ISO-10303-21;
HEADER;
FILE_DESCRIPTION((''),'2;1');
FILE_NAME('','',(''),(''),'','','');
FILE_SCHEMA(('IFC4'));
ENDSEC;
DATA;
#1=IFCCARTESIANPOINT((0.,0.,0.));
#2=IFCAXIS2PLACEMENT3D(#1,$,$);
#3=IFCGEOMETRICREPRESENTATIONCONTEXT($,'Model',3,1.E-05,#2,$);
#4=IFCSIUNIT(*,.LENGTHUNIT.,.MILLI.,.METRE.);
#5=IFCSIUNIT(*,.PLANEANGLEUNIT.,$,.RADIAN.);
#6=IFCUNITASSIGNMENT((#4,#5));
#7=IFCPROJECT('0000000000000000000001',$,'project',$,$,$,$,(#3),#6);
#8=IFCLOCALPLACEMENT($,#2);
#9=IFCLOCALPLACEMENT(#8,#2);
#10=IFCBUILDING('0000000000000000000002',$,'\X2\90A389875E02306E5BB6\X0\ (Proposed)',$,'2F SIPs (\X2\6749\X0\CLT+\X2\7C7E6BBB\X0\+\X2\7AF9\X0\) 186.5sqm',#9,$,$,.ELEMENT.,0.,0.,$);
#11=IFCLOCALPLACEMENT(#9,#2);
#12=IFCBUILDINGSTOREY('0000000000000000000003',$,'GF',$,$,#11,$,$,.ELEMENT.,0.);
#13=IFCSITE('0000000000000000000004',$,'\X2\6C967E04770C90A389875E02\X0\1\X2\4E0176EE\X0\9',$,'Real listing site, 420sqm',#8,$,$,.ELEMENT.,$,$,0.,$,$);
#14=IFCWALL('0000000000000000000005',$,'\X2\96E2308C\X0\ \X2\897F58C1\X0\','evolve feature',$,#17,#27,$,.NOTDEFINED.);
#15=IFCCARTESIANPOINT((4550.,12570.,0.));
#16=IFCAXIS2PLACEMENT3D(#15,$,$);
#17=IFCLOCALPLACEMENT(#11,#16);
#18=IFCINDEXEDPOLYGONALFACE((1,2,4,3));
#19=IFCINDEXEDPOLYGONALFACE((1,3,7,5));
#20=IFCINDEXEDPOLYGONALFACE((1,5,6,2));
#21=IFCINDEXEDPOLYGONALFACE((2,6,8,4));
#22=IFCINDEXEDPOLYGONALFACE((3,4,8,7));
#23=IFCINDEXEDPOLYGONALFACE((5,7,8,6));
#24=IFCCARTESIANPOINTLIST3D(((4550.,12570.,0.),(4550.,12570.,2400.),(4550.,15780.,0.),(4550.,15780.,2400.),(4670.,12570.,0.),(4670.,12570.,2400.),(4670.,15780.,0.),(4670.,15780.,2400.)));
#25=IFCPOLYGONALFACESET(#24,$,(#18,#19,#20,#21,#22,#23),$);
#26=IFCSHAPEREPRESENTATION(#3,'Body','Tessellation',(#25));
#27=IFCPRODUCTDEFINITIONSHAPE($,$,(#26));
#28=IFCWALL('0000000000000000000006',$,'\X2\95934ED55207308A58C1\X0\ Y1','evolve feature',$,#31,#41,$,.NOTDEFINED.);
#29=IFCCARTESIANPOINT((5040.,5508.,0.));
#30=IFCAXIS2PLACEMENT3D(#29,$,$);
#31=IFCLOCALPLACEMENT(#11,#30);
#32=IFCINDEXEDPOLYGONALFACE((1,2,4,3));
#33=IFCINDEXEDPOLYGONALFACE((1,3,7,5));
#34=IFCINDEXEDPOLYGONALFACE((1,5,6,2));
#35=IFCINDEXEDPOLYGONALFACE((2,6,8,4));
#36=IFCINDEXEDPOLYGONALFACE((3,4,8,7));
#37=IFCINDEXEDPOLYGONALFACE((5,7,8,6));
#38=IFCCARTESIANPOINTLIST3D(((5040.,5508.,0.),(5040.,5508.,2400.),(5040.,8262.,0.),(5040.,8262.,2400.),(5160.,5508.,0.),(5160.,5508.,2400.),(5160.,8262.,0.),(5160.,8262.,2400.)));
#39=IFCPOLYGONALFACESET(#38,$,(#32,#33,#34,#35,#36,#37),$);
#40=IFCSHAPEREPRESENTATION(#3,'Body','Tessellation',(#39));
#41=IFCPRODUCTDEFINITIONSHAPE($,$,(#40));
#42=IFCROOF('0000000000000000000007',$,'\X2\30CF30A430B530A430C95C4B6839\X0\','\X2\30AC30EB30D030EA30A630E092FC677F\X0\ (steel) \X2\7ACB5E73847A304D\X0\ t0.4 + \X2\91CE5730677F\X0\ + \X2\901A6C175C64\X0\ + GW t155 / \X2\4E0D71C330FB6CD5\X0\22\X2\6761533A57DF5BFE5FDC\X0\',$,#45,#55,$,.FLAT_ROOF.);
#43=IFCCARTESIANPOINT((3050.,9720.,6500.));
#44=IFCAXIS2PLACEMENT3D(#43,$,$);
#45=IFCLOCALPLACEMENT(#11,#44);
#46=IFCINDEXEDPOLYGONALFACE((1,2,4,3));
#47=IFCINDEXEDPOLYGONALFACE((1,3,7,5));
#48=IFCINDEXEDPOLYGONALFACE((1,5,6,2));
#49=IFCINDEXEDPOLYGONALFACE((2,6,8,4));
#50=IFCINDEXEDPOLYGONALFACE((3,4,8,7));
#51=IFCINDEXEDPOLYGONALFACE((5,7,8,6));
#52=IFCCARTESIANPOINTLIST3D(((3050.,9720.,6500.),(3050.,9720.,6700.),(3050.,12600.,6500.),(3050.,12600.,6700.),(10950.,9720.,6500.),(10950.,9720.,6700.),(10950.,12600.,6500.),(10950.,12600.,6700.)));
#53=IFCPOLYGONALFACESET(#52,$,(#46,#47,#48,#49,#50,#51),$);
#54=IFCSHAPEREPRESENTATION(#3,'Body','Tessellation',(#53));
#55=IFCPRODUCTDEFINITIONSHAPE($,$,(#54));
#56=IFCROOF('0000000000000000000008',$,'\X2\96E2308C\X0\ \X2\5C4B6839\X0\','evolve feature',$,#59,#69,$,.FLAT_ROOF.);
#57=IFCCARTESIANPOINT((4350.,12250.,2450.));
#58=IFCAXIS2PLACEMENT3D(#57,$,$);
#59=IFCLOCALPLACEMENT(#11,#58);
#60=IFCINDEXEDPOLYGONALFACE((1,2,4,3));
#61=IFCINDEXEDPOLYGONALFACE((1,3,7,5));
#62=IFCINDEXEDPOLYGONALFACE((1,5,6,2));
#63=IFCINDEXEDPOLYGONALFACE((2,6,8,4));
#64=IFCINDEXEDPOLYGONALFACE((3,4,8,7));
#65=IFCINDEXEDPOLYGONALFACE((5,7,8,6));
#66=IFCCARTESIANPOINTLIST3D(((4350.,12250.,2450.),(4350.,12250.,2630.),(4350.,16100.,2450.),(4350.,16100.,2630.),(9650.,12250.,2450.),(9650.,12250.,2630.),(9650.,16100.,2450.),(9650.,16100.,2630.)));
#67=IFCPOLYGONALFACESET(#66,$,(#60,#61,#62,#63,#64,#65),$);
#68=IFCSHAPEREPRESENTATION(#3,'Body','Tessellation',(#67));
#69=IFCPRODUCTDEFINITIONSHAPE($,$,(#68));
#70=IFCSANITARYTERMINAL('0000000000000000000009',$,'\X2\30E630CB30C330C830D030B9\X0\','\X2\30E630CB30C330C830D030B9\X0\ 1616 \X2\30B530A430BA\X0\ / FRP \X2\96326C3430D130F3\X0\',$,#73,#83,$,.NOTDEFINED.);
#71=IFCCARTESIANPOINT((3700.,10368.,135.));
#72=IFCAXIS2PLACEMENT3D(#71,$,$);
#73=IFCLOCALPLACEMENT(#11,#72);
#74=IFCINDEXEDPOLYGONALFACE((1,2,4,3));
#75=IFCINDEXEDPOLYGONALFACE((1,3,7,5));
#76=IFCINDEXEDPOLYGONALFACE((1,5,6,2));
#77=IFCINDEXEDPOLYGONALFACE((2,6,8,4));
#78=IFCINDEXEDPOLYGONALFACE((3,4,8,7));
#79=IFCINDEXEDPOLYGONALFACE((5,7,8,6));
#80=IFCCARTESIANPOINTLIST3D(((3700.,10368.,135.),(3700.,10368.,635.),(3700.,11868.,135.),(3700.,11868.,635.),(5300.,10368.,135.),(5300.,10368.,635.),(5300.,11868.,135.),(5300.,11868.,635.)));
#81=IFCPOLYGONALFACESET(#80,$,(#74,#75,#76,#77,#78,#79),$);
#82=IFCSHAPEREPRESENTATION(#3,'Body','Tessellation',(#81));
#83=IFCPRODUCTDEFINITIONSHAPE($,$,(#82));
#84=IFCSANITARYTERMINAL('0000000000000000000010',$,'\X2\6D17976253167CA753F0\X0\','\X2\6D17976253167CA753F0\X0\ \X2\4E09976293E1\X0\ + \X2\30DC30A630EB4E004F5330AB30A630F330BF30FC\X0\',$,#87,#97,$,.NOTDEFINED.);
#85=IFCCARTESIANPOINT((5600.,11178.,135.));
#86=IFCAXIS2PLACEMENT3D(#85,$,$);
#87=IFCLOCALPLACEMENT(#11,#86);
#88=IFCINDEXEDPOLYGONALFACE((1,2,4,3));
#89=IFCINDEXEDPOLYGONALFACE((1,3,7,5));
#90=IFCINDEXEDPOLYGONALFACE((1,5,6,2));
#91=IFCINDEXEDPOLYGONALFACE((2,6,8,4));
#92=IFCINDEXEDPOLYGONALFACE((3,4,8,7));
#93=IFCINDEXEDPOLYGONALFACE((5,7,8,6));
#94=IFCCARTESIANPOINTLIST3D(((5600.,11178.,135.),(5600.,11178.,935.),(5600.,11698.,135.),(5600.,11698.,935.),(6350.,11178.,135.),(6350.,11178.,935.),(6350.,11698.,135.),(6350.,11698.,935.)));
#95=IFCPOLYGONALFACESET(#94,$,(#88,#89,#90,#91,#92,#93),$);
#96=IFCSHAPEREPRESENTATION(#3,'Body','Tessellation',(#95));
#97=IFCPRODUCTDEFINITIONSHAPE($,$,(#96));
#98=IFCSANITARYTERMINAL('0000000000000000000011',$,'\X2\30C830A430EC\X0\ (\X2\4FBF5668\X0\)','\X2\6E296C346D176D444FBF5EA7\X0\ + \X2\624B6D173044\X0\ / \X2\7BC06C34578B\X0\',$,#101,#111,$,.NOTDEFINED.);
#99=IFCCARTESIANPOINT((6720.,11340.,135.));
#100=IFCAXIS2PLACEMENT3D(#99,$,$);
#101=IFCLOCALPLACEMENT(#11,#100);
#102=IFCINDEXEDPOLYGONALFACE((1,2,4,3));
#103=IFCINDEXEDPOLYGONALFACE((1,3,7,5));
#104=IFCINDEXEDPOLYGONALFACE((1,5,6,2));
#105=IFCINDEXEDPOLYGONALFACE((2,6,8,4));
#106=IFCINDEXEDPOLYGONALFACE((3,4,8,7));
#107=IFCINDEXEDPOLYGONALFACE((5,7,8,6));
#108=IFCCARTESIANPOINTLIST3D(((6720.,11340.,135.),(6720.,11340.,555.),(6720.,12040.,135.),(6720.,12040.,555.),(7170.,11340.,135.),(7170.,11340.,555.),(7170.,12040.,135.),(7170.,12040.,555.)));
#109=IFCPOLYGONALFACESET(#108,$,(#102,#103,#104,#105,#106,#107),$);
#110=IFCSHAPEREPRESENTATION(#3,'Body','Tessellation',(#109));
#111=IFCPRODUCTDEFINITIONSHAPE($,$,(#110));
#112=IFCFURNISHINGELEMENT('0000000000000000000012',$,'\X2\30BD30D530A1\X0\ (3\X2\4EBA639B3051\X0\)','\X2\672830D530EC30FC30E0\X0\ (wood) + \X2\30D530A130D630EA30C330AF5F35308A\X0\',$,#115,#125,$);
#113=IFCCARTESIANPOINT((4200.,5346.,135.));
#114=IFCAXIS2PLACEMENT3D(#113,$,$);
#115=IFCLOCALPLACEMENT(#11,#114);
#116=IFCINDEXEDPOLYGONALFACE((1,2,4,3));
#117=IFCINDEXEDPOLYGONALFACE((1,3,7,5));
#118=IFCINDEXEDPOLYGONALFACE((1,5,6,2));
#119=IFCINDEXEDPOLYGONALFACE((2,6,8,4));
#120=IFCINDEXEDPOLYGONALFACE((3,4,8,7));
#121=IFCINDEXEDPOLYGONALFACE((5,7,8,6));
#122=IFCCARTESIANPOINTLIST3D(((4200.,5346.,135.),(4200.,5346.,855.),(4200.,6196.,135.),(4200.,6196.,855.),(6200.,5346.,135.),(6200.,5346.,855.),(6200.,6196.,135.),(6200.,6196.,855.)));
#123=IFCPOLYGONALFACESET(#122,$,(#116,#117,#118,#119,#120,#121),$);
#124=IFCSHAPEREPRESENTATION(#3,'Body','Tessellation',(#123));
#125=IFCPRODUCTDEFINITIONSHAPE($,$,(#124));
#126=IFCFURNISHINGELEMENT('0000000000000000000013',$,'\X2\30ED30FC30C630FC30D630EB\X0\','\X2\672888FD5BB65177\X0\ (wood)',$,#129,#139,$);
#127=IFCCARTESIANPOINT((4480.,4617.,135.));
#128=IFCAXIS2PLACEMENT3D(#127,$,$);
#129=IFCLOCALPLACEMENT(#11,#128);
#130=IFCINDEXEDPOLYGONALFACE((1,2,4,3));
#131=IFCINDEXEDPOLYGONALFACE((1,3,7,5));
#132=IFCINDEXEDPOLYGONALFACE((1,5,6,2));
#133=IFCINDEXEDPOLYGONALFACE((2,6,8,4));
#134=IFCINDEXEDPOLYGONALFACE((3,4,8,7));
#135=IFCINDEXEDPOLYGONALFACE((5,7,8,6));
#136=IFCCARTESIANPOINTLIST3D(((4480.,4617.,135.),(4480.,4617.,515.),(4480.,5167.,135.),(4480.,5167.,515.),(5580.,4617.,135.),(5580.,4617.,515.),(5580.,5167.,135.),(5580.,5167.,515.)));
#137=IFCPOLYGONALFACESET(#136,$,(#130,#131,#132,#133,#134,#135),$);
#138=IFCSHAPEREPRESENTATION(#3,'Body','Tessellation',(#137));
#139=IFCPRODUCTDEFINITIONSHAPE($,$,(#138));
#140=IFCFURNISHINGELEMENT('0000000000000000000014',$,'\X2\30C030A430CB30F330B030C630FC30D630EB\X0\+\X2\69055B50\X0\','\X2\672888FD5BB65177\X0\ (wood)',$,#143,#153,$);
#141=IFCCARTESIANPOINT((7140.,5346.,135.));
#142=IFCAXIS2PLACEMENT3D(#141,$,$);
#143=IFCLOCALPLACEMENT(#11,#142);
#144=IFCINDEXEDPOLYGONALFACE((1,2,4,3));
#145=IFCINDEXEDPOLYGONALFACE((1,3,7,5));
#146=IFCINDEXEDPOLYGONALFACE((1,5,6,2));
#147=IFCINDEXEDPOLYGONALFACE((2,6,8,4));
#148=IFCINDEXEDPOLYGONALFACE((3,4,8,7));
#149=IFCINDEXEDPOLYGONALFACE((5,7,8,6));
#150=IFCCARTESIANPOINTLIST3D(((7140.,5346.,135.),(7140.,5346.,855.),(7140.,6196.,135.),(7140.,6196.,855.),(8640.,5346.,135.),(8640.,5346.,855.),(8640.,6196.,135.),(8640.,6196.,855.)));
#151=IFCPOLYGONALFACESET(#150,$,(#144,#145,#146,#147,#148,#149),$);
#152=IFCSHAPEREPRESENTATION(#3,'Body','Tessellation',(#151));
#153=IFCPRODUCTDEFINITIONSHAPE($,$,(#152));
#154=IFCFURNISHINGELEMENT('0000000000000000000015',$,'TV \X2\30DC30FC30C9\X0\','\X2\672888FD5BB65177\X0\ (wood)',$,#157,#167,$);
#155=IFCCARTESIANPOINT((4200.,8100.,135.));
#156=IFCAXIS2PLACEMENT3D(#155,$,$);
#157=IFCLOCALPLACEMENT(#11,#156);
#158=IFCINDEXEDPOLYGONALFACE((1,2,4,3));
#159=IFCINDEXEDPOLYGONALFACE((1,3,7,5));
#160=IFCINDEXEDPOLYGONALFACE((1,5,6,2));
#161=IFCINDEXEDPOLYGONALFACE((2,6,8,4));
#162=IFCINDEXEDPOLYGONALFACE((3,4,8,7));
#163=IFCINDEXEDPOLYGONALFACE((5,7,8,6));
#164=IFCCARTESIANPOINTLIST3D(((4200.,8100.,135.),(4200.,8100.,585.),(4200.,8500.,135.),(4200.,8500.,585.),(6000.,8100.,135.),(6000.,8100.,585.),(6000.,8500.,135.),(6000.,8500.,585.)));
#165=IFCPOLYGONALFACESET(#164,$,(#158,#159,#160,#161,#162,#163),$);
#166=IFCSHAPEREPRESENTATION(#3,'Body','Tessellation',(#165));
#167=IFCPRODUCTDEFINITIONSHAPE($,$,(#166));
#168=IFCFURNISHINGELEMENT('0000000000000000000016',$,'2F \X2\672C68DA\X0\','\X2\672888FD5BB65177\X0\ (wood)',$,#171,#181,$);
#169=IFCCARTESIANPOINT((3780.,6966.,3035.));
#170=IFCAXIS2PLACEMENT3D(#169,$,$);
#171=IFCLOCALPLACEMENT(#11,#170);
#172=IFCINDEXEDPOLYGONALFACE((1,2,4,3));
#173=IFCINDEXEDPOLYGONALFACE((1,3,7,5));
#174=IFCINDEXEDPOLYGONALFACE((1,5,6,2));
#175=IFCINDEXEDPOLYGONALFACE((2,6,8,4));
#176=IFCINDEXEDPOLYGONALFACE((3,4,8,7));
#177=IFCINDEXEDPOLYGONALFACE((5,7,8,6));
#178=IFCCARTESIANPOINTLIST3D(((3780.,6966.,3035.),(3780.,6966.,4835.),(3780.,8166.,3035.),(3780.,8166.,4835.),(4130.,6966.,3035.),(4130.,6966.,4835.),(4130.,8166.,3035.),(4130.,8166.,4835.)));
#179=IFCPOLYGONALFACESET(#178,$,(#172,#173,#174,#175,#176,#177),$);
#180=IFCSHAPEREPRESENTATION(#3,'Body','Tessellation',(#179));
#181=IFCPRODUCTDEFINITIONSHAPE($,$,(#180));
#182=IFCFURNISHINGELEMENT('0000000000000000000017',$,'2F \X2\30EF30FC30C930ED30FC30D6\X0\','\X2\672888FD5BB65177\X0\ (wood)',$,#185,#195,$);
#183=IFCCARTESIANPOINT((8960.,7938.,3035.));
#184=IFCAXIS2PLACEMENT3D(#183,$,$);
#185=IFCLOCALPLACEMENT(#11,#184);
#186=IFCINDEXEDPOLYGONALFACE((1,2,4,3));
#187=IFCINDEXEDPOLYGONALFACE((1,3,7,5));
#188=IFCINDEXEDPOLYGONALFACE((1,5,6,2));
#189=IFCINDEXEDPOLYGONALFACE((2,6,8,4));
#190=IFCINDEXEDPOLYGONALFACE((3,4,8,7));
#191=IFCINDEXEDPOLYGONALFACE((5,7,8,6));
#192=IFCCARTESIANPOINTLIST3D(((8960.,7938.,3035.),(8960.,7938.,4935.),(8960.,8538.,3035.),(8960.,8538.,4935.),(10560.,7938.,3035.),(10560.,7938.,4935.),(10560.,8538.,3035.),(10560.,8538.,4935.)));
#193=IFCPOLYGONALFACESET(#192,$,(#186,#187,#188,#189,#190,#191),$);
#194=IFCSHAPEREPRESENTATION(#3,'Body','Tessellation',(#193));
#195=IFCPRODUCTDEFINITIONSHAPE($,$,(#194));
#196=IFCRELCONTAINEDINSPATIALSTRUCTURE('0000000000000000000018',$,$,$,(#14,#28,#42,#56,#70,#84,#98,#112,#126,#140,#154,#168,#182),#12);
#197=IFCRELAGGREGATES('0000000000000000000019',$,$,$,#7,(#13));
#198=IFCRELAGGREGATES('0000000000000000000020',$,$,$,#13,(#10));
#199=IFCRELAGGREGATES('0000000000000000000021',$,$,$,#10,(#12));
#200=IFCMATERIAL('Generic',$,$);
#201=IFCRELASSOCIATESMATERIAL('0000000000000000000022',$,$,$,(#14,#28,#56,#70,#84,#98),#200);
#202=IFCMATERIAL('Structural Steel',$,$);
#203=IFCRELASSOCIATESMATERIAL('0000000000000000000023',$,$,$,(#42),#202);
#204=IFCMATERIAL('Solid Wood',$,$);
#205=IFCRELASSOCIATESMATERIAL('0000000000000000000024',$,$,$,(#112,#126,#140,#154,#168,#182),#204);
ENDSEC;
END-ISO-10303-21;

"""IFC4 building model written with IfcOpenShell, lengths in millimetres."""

from ifc_helpers import new_model, si_unit, frame, frame_2d, origin, place, context, project, spatial, rectangle, extrude, material, element, save


model = new_model("IFC4")

# Units and contexts
model_context = context("Model", 3, precision=1e-05, world=origin())
ifc_project = project(units=[si_unit("LENGTHUNIT", "METRE", prefix="MILLI"), si_unit("PLANEANGLEUNIT", "RADIAN")], contexts=[model_context])

# Site, building, storey
site_placement = place(None, origin())
site = spatial("IfcSite", under=ifc_project, at=site_placement, Name="沖縄県那覇市1丁目9", ObjectType="Real listing site, 420sqm", CompositionType="ELEMENT", RefElevation=0.0)
building_placement = place(site_placement, origin())
building = spatial("IfcBuilding", under=site, at=building_placement, Name="那覇市の家 (Proposed)", ObjectType="2F SIPs (杉CLT+籾殻+竹) 186.5sqm", CompositionType="ELEMENT", ElevationOfRefHeight=0.0, ElevationOfTerrain=0.0)
storey_placement = place(building_placement, origin())
storey = spatial("IfcBuildingStorey", under=building, at=storey_placement, Name="GF", CompositionType="ELEMENT", Elevation=0.0)

# Shared definitions
ifc_material_1 = material(Name="Generic")

# Shared definitions
ifc_material_2 = material(Name="Solid Wood")

# Walls
wall_1_placement = place(storey_placement, frame((4550.0, 12570.0, 0.0)))
element("IfcWall", 1, at=wall_1_placement, inside=storey, material=ifc_material_1, Name="離れ 西壁", Description="evolve feature", PredefinedType="NOTDEFINED", context=model_context, shape_type="SweptSolid", body=[
    extrude(rectangle(XDim=120.0, YDim=3210.0, at=frame_2d((60.0, 1605.0))), frame((4550.0, 12570.0, 0.0)), (0.0, 0.0, 1.0), 2400.0),
])
wall_2_placement = place(storey_placement, frame((5040.0, 5508.0, 0.0)))
element("IfcWall", 2, at=wall_2_placement, inside=storey, material=ifc_material_1, Name="間仕切り壁 Y1", Description="evolve feature", PredefinedType="NOTDEFINED", context=model_context, shape_type="SweptSolid", body=[
    extrude(rectangle(XDim=120.0, YDim=2754.0, at=frame_2d((60.0, 1377.0))), frame((5040.0, 5508.0, 0.0)), (0.0, 0.0, 1.0), 2400.0),
])

# Roofs
ifc_material_3 = material(Name="Structural Steel")
roof_1_placement = place(storey_placement, frame((3050.0, 9720.0, 6500.0)))
element("IfcRoof", 3, at=roof_1_placement, inside=storey, material=ifc_material_3, Name="ハイサイド屋根", Description="ガルバリウム鋼板 (steel) 立平葺き t0.4 + 野地板 + 通気層 + GW t155 / 不燃・法22条区域対応", PredefinedType="FLAT_ROOF", context=model_context, shape_type="SweptSolid", body=[
    extrude(rectangle(XDim=7900.0, YDim=2880.0, at=frame_2d((3950.0, 1440.0))), frame((3050.0, 9720.0, 6500.0)), (0.0, 0.0, 1.0), 200.0),
])
roof_2_placement = place(storey_placement, frame((4350.0, 12250.0, 2450.0)))
element("IfcRoof", 4, at=roof_2_placement, inside=storey, material=ifc_material_1, Name="離れ 屋根", Description="evolve feature", PredefinedType="FLAT_ROOF", context=model_context, shape_type="SweptSolid", body=[
    extrude(rectangle(XDim=5300.0, YDim=3850.0, at=frame_2d((2650.0, 1925.0))), frame((4350.0, 12250.0, 2450.0)), (0.0, 0.0, 1.0), 180.0),
])

# Sanitary terminals
sanitary_terminal_1_placement = place(storey_placement, frame((3700.0, 10368.0, 135.0)))
element("IfcSanitaryTerminal", 5, at=sanitary_terminal_1_placement, inside=storey, material=ifc_material_1, Name="ユニットバス", Description="ユニットバス 1616 サイズ / FRP 防水パン", PredefinedType="NOTDEFINED", context=model_context, shape_type="SweptSolid", body=[
    extrude(rectangle(XDim=1600.0, YDim=1500.0, at=frame_2d((800.0, 750.0))), frame((3700.0, 10368.0, 135.0)), (0.0, 0.0, 1.0), 500.0),
])
sanitary_terminal_2_placement = place(storey_placement, frame((5600.0, 11178.0, 135.0)))
element("IfcSanitaryTerminal", 6, at=sanitary_terminal_2_placement, inside=storey, material=ifc_material_1, Name="洗面化粧台", Description="洗面化粧台 三面鏡 + ボウル一体カウンター", PredefinedType="NOTDEFINED", context=model_context, shape_type="SweptSolid", body=[
    extrude(rectangle(XDim=750.0, YDim=520.0, at=frame_2d((375.0, 260.0))), frame((5600.0, 11178.0, 135.0)), (0.0, 0.0, 1.0), 800.0),
])
sanitary_terminal_3_placement = place(storey_placement, frame((6720.0, 11340.0, 135.0)))
element("IfcSanitaryTerminal", 7, at=sanitary_terminal_3_placement, inside=storey, material=ifc_material_1, Name="トイレ (便器)", Description="温水洗浄便座 + 手洗い / 節水型", PredefinedType="NOTDEFINED", context=model_context, shape_type="SweptSolid", body=[
    extrude(rectangle(XDim=450.0, YDim=700.0, at=frame_2d((225.0, 350.0))), frame((6720.0, 11340.0, 135.0)), (0.0, 0.0, 1.0), 420.0),
])

# Furnishing elements
furnishing_1_placement = place(storey_placement, frame((4200.0, 5346.0, 135.0)))
element("IfcFurnishingElement", 8, at=furnishing_1_placement, inside=storey, material=ifc_material_2, Name="ソファ (3人掛け)", Description="木フレーム (wood) + ファブリック張り", context=model_context, shape_type="SweptSolid", body=[
    extrude(rectangle(XDim=2000.0, YDim=850.0, at=frame_2d((1000.0, 425.0))), frame((4200.0, 5346.0, 135.0)), (0.0, 0.0, 1.0), 720.0),
])
furnishing_2_placement = place(storey_placement, frame((4480.0, 4617.0, 135.0)))
element("IfcFurnishingElement", 9, at=furnishing_2_placement, inside=storey, material=ifc_material_2, Name="ローテーブル", Description="木製家具 (wood)", context=model_context, shape_type="SweptSolid", body=[
    extrude(rectangle(XDim=1100.0, YDim=550.0, at=frame_2d((550.0, 275.0))), frame((4480.0, 4617.0, 135.0)), (0.0, 0.0, 1.0), 380.0),
])
furnishing_3_placement = place(storey_placement, frame((7140.0, 5346.0, 135.0)))
element("IfcFurnishingElement", 10, at=furnishing_3_placement, inside=storey, material=ifc_material_2, Name="ダイニングテーブル+椅子", Description="木製家具 (wood)", context=model_context, shape_type="SweptSolid", body=[
    extrude(rectangle(XDim=1500.0, YDim=850.0, at=frame_2d((750.0, 425.0))), frame((7140.0, 5346.0, 135.0)), (0.0, 0.0, 1.0), 720.0),
])
furnishing_4_placement = place(storey_placement, frame((4200.0, 8100.0, 135.0)))
element("IfcFurnishingElement", 11, at=furnishing_4_placement, inside=storey, material=ifc_material_2, Name="TV ボード", Description="木製家具 (wood)", context=model_context, shape_type="SweptSolid", body=[
    extrude(rectangle(XDim=1800.0, YDim=400.0, at=frame_2d((900.0, 200.0))), frame((4200.0, 8100.0, 135.0)), (0.0, 0.0, 1.0), 450.0),
])
furnishing_5_placement = place(storey_placement, frame((3780.0, 6966.0, 3035.0)))
element("IfcFurnishingElement", 12, at=furnishing_5_placement, inside=storey, material=ifc_material_2, Name="2F 本棚", Description="木製家具 (wood)", context=model_context, shape_type="SweptSolid", body=[
    extrude(rectangle(XDim=350.0, YDim=1200.0, at=frame_2d((175.0, 600.0))), frame((3780.0, 6966.0, 3035.0)), (0.0, 0.0, 1.0), 1800.0),
])
furnishing_6_placement = place(storey_placement, frame((8960.0, 7938.0, 3035.0)))
element("IfcFurnishingElement", 13, at=furnishing_6_placement, inside=storey, material=ifc_material_2, Name="2F ワードローブ", Description="木製家具 (wood)", context=model_context, shape_type="SweptSolid", body=[
    extrude(rectangle(XDim=1600.0, YDim=600.0, at=frame_2d((800.0, 300.0))), frame((8960.0, 7938.0, 3035.0)), (0.0, 0.0, 1.0), 1900.0),
])

save(model, "model.ifc")
